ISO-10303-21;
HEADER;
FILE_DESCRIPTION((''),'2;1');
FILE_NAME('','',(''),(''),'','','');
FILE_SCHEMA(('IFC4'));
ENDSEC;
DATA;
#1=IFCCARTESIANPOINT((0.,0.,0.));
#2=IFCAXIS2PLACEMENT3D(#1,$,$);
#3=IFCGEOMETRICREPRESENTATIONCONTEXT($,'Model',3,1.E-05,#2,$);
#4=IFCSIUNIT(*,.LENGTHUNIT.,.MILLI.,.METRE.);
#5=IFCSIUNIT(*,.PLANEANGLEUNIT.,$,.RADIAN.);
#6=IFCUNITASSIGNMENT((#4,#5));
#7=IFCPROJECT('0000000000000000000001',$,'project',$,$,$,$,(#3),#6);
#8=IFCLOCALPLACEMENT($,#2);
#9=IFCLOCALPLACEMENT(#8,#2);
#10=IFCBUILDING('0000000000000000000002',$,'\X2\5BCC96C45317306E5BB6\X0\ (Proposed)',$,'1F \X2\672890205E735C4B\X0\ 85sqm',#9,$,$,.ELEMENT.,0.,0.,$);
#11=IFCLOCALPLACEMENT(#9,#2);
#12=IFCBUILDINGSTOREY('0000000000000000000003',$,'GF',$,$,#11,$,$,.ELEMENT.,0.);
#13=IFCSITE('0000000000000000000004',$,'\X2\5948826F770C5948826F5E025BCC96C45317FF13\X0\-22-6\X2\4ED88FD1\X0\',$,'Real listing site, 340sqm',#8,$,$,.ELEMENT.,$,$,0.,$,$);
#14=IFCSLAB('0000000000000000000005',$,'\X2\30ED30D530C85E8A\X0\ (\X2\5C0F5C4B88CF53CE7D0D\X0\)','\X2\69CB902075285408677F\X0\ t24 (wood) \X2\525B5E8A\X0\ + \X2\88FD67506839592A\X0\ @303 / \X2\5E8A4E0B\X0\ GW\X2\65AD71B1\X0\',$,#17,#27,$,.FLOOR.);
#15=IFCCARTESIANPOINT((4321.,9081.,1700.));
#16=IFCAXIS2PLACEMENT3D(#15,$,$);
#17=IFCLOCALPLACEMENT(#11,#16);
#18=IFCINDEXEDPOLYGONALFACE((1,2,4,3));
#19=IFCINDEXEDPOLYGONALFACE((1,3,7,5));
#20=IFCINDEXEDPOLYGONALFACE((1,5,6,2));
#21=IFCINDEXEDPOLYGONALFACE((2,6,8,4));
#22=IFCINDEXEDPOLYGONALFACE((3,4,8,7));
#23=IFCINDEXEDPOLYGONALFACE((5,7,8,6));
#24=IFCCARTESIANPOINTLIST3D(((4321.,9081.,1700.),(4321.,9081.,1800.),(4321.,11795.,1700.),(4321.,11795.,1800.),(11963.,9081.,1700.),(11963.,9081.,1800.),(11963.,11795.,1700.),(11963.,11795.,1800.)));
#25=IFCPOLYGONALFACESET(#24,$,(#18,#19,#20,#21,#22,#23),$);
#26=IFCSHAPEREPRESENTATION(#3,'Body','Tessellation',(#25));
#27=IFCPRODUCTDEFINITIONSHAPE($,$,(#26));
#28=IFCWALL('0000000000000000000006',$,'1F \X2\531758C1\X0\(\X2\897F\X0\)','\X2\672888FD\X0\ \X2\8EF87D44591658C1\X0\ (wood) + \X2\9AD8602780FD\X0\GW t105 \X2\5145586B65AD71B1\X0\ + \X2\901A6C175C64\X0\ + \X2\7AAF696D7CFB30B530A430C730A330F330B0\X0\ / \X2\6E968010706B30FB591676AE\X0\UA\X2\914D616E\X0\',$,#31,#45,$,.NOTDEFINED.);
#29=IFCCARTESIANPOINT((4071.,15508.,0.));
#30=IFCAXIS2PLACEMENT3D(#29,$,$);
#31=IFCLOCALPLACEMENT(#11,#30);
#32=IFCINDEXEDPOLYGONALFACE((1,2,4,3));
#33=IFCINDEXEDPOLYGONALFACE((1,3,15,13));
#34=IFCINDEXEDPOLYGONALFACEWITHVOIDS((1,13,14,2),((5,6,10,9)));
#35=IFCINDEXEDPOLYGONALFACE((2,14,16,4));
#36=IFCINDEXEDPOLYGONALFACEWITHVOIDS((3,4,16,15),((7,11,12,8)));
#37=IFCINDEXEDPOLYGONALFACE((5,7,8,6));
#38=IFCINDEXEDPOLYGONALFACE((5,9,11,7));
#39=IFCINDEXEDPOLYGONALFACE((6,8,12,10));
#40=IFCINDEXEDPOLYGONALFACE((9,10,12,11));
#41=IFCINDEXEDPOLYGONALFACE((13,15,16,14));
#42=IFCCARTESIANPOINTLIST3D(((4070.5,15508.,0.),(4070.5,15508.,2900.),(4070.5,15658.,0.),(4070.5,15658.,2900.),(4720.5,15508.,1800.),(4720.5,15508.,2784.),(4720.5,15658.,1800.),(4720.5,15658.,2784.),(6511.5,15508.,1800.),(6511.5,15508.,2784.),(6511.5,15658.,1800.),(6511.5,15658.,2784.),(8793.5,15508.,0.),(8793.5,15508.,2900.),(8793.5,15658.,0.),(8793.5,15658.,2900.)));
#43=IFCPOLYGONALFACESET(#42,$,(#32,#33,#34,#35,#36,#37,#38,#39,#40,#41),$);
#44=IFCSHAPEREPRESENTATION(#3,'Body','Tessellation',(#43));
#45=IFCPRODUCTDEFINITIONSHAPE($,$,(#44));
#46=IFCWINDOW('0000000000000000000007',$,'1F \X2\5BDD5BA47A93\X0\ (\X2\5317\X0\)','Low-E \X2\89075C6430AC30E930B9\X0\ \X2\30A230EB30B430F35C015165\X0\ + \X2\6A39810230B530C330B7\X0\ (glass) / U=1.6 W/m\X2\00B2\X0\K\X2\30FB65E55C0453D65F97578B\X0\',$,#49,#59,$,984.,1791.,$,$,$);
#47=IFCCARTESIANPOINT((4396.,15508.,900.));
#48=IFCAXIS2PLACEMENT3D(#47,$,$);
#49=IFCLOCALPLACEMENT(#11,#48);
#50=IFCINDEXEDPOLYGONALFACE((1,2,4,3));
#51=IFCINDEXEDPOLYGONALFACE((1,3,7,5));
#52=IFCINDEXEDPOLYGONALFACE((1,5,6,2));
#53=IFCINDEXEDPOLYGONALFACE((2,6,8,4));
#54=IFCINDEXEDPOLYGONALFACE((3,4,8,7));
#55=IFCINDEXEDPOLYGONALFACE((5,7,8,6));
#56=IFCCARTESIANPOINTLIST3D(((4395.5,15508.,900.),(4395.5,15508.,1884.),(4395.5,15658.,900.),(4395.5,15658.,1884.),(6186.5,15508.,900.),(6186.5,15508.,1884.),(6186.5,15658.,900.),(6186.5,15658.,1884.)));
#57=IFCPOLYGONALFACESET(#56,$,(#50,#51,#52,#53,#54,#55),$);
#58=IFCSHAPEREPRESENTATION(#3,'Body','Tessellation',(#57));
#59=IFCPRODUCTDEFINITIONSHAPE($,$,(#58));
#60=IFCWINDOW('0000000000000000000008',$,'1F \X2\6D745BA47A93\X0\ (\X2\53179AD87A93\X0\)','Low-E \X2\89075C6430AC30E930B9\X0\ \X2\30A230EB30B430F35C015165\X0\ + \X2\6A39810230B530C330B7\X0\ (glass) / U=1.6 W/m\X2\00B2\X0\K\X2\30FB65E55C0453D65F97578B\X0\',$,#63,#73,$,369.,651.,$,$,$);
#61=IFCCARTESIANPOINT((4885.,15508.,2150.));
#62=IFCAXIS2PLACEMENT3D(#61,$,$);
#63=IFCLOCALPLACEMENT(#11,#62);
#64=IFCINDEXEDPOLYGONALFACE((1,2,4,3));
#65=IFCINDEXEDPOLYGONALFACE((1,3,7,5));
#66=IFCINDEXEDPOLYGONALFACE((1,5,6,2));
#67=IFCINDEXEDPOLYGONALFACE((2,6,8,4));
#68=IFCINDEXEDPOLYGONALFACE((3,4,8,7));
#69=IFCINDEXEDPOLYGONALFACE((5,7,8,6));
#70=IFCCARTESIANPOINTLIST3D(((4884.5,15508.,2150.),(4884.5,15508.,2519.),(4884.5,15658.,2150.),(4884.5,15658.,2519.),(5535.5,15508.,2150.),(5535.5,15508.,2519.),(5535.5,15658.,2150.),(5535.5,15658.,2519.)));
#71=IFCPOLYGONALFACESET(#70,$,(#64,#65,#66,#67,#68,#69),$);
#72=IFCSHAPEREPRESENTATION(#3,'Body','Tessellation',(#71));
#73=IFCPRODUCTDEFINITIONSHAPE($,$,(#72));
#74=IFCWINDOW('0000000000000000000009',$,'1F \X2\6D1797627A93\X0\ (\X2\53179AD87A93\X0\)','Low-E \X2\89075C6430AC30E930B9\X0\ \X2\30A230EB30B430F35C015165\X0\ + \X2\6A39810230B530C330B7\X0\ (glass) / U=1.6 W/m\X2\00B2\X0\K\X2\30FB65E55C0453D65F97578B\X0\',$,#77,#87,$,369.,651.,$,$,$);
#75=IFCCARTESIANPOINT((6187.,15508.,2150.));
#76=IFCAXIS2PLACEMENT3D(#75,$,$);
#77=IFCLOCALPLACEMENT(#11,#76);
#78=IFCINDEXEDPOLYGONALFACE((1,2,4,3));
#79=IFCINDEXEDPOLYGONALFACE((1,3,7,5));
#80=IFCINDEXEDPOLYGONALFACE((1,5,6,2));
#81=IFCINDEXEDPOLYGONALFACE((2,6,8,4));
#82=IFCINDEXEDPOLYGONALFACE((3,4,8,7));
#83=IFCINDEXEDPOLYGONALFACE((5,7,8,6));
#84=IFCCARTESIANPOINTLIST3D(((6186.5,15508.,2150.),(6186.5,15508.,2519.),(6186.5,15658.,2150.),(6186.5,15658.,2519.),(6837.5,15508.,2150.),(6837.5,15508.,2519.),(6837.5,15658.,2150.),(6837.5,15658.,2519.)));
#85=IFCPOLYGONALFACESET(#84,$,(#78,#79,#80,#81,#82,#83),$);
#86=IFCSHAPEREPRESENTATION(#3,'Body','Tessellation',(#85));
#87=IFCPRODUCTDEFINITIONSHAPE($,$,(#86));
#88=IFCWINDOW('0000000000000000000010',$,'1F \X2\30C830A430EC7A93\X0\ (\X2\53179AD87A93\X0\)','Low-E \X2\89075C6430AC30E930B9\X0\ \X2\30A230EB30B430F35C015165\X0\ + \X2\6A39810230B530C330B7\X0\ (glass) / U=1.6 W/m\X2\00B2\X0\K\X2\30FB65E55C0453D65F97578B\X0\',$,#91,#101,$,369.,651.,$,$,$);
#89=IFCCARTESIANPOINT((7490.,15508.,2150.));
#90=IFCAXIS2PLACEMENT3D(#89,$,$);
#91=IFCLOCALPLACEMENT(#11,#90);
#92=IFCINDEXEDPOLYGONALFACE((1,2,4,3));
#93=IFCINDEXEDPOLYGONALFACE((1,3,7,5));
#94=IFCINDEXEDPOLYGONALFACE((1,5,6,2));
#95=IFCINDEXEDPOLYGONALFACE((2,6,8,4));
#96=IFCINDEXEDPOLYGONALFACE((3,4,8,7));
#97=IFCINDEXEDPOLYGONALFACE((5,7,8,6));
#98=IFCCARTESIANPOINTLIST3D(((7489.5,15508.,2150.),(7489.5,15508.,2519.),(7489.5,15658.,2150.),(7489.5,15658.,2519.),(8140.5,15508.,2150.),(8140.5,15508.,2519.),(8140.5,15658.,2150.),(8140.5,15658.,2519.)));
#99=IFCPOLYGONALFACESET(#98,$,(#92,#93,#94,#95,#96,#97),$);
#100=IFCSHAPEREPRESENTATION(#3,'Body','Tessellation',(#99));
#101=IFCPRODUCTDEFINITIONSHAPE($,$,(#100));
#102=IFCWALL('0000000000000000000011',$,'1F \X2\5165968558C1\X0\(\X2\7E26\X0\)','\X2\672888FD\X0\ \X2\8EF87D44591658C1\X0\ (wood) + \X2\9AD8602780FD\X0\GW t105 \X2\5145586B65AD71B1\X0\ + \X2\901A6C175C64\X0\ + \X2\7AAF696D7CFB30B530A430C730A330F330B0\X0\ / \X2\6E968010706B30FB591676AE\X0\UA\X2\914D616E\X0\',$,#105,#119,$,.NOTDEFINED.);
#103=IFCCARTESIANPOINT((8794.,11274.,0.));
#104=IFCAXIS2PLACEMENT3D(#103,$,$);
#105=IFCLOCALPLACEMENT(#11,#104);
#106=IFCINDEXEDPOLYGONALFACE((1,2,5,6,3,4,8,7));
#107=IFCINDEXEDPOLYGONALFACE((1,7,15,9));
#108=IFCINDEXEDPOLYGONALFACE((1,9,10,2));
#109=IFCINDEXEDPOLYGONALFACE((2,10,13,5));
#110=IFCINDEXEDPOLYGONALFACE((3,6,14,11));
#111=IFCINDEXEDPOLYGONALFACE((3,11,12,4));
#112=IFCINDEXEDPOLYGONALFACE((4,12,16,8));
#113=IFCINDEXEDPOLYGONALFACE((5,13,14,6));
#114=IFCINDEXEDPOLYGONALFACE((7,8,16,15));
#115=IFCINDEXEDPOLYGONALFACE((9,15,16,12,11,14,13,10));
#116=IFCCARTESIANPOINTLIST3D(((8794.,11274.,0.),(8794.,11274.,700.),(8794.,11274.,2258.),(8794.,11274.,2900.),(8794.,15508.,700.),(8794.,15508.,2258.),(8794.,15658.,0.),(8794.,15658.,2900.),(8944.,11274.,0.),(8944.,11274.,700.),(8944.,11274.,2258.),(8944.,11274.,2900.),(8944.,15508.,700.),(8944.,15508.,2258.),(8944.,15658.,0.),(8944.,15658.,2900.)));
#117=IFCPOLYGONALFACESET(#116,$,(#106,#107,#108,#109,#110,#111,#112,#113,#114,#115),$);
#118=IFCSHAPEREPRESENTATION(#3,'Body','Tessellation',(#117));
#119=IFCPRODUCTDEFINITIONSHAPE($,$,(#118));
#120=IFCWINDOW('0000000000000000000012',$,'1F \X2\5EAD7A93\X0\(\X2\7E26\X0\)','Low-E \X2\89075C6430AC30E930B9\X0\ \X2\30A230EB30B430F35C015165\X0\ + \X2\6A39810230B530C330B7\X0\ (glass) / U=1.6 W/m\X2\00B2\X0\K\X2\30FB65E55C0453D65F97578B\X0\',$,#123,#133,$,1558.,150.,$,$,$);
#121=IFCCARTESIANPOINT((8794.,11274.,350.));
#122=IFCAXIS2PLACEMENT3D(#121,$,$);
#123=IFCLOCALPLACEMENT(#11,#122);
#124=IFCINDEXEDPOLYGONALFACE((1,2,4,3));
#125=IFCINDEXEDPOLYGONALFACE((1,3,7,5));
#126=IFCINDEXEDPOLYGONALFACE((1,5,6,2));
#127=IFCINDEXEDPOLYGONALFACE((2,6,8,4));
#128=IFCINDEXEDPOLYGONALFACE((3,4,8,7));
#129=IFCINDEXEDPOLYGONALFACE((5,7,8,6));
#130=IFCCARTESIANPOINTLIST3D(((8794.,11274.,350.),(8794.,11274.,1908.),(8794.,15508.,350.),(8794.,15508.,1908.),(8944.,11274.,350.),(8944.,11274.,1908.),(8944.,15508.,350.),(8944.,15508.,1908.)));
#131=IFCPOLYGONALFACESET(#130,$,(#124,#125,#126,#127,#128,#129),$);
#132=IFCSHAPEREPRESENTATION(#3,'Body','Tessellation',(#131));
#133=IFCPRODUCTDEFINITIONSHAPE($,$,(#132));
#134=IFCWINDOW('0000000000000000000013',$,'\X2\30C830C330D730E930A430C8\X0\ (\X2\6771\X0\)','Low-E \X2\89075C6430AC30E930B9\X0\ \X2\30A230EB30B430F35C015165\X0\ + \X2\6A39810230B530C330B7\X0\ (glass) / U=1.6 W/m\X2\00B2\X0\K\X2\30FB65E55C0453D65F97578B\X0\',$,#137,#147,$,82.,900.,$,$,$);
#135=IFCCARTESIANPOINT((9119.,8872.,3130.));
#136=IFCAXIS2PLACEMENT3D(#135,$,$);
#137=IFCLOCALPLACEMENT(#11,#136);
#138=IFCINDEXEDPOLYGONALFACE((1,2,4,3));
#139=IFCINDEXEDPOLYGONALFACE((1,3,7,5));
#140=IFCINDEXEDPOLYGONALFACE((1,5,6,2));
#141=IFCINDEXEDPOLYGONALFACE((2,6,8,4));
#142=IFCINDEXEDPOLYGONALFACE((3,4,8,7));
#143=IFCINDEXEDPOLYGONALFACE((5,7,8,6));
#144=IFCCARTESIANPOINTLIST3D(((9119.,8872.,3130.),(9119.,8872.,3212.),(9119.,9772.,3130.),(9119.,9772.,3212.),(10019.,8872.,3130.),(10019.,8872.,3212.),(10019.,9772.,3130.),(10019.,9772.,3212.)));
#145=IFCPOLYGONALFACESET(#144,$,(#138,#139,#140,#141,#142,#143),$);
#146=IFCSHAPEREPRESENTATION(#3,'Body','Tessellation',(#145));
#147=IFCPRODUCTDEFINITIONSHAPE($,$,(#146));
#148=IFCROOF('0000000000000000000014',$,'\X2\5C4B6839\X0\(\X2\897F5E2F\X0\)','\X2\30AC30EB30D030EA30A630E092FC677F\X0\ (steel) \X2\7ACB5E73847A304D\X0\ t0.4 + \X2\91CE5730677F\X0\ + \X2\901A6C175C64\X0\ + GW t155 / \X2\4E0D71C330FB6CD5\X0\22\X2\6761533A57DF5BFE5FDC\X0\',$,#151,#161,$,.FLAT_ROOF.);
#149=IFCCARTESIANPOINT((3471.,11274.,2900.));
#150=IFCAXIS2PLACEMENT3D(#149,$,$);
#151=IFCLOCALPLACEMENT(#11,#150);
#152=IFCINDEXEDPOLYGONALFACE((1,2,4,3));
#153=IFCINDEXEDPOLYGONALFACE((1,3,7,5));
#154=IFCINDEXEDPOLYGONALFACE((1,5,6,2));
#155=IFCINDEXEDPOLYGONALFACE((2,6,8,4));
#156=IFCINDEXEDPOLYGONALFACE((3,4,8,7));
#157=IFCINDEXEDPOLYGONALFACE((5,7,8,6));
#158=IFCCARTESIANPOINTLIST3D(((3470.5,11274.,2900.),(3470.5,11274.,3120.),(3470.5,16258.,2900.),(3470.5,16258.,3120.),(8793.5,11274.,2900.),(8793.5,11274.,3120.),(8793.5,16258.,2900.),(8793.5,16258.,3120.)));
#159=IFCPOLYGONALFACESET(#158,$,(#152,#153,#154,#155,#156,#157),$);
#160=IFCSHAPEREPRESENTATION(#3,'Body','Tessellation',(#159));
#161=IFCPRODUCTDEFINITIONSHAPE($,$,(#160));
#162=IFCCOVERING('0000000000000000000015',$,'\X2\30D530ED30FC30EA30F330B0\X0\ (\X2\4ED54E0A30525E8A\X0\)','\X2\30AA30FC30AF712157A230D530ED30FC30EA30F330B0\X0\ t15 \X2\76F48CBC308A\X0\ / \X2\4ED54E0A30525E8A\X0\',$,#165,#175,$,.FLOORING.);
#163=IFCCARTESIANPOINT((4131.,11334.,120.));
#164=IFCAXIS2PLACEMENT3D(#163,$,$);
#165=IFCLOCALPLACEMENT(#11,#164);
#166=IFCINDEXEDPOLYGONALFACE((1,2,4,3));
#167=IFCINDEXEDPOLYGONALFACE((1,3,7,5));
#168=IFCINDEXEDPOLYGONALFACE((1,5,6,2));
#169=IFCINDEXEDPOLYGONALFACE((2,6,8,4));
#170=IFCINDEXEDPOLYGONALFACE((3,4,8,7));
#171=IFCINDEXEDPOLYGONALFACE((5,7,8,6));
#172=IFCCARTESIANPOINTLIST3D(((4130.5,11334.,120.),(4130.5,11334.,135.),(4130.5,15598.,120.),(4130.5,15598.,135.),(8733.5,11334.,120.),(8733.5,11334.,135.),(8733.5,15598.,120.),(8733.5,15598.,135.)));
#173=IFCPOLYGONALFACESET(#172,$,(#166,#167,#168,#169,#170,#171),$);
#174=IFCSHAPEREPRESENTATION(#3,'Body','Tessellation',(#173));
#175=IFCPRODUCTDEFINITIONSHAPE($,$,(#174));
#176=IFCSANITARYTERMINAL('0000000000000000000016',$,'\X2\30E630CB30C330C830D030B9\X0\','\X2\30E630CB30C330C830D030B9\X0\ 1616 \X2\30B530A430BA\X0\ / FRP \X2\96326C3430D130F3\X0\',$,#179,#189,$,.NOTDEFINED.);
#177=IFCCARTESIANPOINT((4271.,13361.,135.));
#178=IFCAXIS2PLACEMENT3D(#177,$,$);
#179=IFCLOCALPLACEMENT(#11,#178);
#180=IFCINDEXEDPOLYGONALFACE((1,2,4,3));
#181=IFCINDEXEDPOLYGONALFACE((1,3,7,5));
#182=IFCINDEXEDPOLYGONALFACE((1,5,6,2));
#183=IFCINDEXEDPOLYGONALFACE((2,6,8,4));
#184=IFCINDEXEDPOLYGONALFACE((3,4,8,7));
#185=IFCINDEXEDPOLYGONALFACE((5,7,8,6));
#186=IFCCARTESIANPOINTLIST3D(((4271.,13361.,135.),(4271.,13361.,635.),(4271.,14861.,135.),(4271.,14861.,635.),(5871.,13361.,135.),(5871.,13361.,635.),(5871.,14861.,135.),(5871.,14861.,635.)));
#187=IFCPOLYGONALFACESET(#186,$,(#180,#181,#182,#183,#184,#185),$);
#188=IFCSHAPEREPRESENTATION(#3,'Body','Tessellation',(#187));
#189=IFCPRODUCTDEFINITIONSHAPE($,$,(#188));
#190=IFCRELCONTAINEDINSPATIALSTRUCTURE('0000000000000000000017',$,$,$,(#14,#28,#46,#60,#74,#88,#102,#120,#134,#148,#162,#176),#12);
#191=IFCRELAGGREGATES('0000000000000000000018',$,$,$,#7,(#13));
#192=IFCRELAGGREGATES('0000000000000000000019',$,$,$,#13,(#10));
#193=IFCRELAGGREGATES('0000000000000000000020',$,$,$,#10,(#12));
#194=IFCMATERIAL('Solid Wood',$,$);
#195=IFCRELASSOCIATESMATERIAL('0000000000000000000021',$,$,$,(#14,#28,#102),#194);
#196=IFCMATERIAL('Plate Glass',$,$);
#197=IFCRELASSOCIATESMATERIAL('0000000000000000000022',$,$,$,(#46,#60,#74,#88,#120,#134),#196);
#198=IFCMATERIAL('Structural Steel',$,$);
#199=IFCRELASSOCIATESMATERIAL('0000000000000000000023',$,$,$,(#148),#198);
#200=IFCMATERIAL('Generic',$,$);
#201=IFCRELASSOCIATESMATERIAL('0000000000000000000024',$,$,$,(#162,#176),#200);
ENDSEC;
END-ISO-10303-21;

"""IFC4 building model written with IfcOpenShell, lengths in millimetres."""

from ifc_helpers import new_model, si_unit, frame, frame_2d, origin, place, context, project, spatial, rectangle, extrude, material, element, fill, save


model = new_model("IFC4")

# Units and contexts
model_context = context("Model", 3, precision=1e-05, world=origin())
ifc_project = project(units=[si_unit("LENGTHUNIT", "METRE", prefix="MILLI"), si_unit("PLANEANGLEUNIT", "RADIAN")], contexts=[model_context])

# Site, building, storey
site_placement = place(None, origin())
site = spatial("IfcSite", under=ifc_project, at=site_placement, Name="奈良県奈良市富雄北３-22-6付近", ObjectType="Real listing site, 340sqm", CompositionType="ELEMENT", RefElevation=0.0)
building_placement = place(site_placement, origin())
building = spatial("IfcBuilding", under=site, at=building_placement, Name="富雄北の家 (Proposed)", ObjectType="1F 木造平屋 85sqm", CompositionType="ELEMENT", ElevationOfRefHeight=0.0, ElevationOfTerrain=0.0)
storey_placement = place(building_placement, origin())
storey = spatial("IfcBuildingStorey", under=building, at=storey_placement, Name="GF", CompositionType="ELEMENT", Elevation=0.0)

# Slab
ifc_material_1 = material(Name="Solid Wood")
slab_1_placement = place(storey_placement, frame((4321.0, 9081.0, 1700.0)))
element("IfcSlab", 1, at=slab_1_placement, inside=storey, material=ifc_material_1, Name="ロフト床 (小屋裏収納)", Description="構造用合板 t24 (wood) 剛床 + 製材根太 @303 / 床下 GW断熱", PredefinedType="FLOOR", context=model_context, shape_type="SweptSolid", body=[
    extrude(rectangle(XDim=7642.0, YDim=2714.0, at=frame_2d((3821.0, 1357.0))), frame((4321.0, 9081.0, 1700.0)), (0.0, 0.0, 1.0), 100.0),
])

# Wall, openings, windows
wall_1_placement = place(storey_placement, frame((4071.0, 15508.0, 0.0)))
wall_1 = element("IfcWall", 2, at=wall_1_placement, inside=storey, material=ifc_material_1, Name="1F 北壁(西)", Description="木製 軸組外壁 (wood) + 高性能GW t105 充填断熱 + 通気層 + 窯業系サイディング / 準耐火・外皮UA配慮", PredefinedType="NOTDEFINED", context=model_context, shape_type="SweptSolid", body=[
    extrude(rectangle(XDim=4723.0, YDim=150.0, at=frame_2d((2361.0, 75.0))), frame((4071.0, 15508.0, 0.0)), (0.0, 0.0, 1.0), 2900.0),
])
opening_1_placement = place(storey_placement, frame((4396.0, 15508.0, 900.0)))
opening_1 = element("IfcOpeningElement", 3, at=opening_1_placement, cuts=wall_1, PredefinedType="NOTDEFINED", context=model_context, shape_type="SweptSolid", body=[
    extrude(rectangle(XDim=1791.0, YDim=150.0, at=frame_2d((895.0, 75.0))), frame((4396.0, 15508.0, 900.0)), (0.0, 0.0, 1.0), 984.0),
])
opening_2_placement = place(storey_placement, frame((4885.0, 15508.0, 2150.0)))
opening_2 = element("IfcOpeningElement", 4, at=opening_2_placement, cuts=wall_1, PredefinedType="NOTDEFINED", context=model_context, shape_type="SweptSolid", body=[
    extrude(rectangle(XDim=651.0, YDim=150.0, at=frame_2d((325.0, 75.0))), frame((4885.0, 15508.0, 2150.0)), (0.0, 0.0, 1.0), 369.0),
])
opening_3_placement = place(storey_placement, frame((6187.0, 15508.0, 2150.0)))
opening_3 = element("IfcOpeningElement", 5, at=opening_3_placement, cuts=wall_1, PredefinedType="NOTDEFINED", context=model_context, shape_type="SweptSolid", body=[
    extrude(rectangle(XDim=651.0, YDim=150.0, at=frame_2d((325.0, 75.0))), frame((6187.0, 15508.0, 2150.0)), (0.0, 0.0, 1.0), 369.0),
])
opening_4_placement = place(storey_placement, frame((7490.0, 15508.0, 2150.0)))
opening_4 = element("IfcOpeningElement", 6, at=opening_4_placement, cuts=wall_1, PredefinedType="NOTDEFINED", context=model_context, shape_type="SweptSolid", body=[
    extrude(rectangle(XDim=651.0, YDim=150.0, at=frame_2d((325.0, 75.0))), frame((7490.0, 15508.0, 2150.0)), (0.0, 0.0, 1.0), 369.0),
])
ifc_material_2 = material(Name="Plate Glass")
window_1_placement = place(storey_placement, frame((4396.0, 15508.0, 900.0)))
window_1 = element("IfcWindow", 7, at=window_1_placement, inside=storey, material=ifc_material_2, Name="1F 寝室窓 (北)", Description="Low-E 複層ガラス アルゴン封入 + 樹脂サッシ (glass) / U=1.6 W/m²K・日射取得型", OverallHeight=984.0, OverallWidth=1791.0, context=model_context, shape_type="SweptSolid", body=[
    extrude(rectangle(XDim=1791.0, YDim=150.0, at=frame_2d((895.0, 75.0))), frame((4396.0, 15508.0, 900.0)), (0.0, 0.0, 1.0), 984.0),
])
fill(opening_1, window_1)
window_2_placement = place(storey_placement, frame((4885.0, 15508.0, 2150.0)))
window_2 = element("IfcWindow", 8, at=window_2_placement, inside=storey, material=ifc_material_2, Name="1F 浴室窓 (北高窓)", Description="Low-E 複層ガラス アルゴン封入 + 樹脂サッシ (glass) / U=1.6 W/m²K・日射取得型", OverallHeight=369.0, OverallWidth=651.0, context=model_context, shape_type="SweptSolid", body=[
    extrude(rectangle(XDim=651.0, YDim=150.0, at=frame_2d((325.0, 75.0))), frame((4885.0, 15508.0, 2150.0)), (0.0, 0.0, 1.0), 369.0),
])
fill(opening_2, window_2)
window_3_placement = place(storey_placement, frame((6187.0, 15508.0, 2150.0)))
window_3 = element("IfcWindow", 9, at=window_3_placement, inside=storey, material=ifc_material_2, Name="1F 洗面窓 (北高窓)", Description="Low-E 複層ガラス アルゴン封入 + 樹脂サッシ (glass) / U=1.6 W/m²K・日射取得型", OverallHeight=369.0, OverallWidth=651.0, context=model_context, shape_type="SweptSolid", body=[
    extrude(rectangle(XDim=651.0, YDim=150.0, at=frame_2d((325.0, 75.0))), frame((6187.0, 15508.0, 2150.0)), (0.0, 0.0, 1.0), 369.0),
])
fill(opening_3, window_3)
window_4_placement = place(storey_placement, frame((7490.0, 15508.0, 2150.0)))
window_4 = element("IfcWindow", 10, at=window_4_placement, inside=storey, material=ifc_material_2, Name="1F トイレ窓 (北高窓)", Description="Low-E 複層ガラス アルゴン封入 + 樹脂サッシ (glass) / U=1.6 W/m²K・日射取得型", OverallHeight=369.0, OverallWidth=651.0, context=model_context, shape_type="SweptSolid", body=[
    extrude(rectangle(XDim=651.0, YDim=150.0, at=frame_2d((325.0, 75.0))), frame((7490.0, 15508.0, 2150.0)), (0.0, 0.0, 1.0), 369.0),
])
fill(opening_4, window_4)

# Wall, opening, window
wall_2_placement = place(storey_placement, frame((8794.0, 11274.0, 0.0)))
wall_2 = element("IfcWall", 11, at=wall_2_placement, inside=storey, material=ifc_material_1, Name="1F 入隅壁(縦)", Description="木製 軸組外壁 (wood) + 高性能GW t105 充填断熱 + 通気層 + 窯業系サイディング / 準耐火・外皮UA配慮", PredefinedType="NOTDEFINED", context=model_context, shape_type="SweptSolid", body=[
    extrude(rectangle(XDim=150.0, YDim=4384.0, at=frame_2d((75.0, 2192.0))), frame((8794.0, 11274.0, 0.0)), (0.0, 0.0, 1.0), 2900.0),
])
opening_5_placement = place(storey_placement, frame((8794.0, 11274.0, 350.0)))
opening_5 = element("IfcOpeningElement", 12, at=opening_5_placement, cuts=wall_2, PredefinedType="NOTDEFINED", context=model_context, shape_type="SweptSolid", body=[
    extrude(rectangle(XDim=150.0, YDim=4234.0, at=frame_2d((75.0, 2117.0))), frame((8794.0, 11274.0, 350.0)), (0.0, 0.0, 1.0), 1558.0),
])
window_5_placement = place(storey_placement, frame((8794.0, 11274.0, 350.0)))
window_5 = element("IfcWindow", 13, at=window_5_placement, inside=storey, material=ifc_material_2, Name="1F 庭窓(縦)", Description="Low-E 複層ガラス アルゴン封入 + 樹脂サッシ (glass) / U=1.6 W/m²K・日射取得型", OverallHeight=1558.0, OverallWidth=150.0, context=model_context, shape_type="SweptSolid", body=[
    extrude(rectangle(XDim=150.0, YDim=4234.0, at=frame_2d((75.0, 2117.0))), frame((8794.0, 11274.0, 350.0)), (0.0, 0.0, 1.0), 1558.0),
])
fill(opening_5, window_5)

# Window
window_6_placement = place(storey_placement, frame((9119.0, 8872.0, 3130.0)))
element("IfcWindow", 14, at=window_6_placement, inside=storey, material=ifc_material_2, Name="トップライト (東)", Description="Low-E 複層ガラス アルゴン封入 + 樹脂サッシ (glass) / U=1.6 W/m²K・日射取得型", OverallHeight=82.0, OverallWidth=900.0, context=model_context, shape_type="SweptSolid", body=[
    extrude(rectangle(XDim=900.0, YDim=900.0, at=frame_2d((450.0, 450.0))), frame((9119.0, 8872.0, 3130.0)), (0.0, 0.0, 1.0), 82.0),
])

# Roof
ifc_material_3 = material(Name="Structural Steel")
roof_placement = place(storey_placement, frame((3471.0, 11274.0, 2900.0)))
element("IfcRoof", 15, at=roof_placement, inside=storey, material=ifc_material_3, Name="屋根(西帯)", Description="ガルバリウム鋼板 (steel) 立平葺き t0.4 + 野地板 + 通気層 + GW t155 / 不燃・法22条区域対応", PredefinedType="FLAT_ROOF", context=model_context, shape_type="SweptSolid", body=[
    extrude(rectangle(XDim=5323.0, YDim=4984.0, at=frame_2d((2661.0, 2492.0))), frame((3471.0, 11274.0, 2900.0)), (0.0, 0.0, 1.0), 220.0),
])

# Covering
ifc_material_4 = material(Name="Generic")
covering_placement = place(storey_placement, frame((4131.0, 11334.0, 120.0)))
element("IfcCovering", 16, at=covering_placement, inside=storey, material=ifc_material_4, Name="フローリング (仕上げ床)", Description="オーク無垢フローリング t15 直貼り / 仕上げ床", PredefinedType="FLOORING", context=model_context, shape_type="SweptSolid", body=[
    extrude(rectangle(XDim=4603.0, YDim=4264.0, at=frame_2d((2301.0, 2132.0))), frame((4131.0, 11334.0, 120.0)), (0.0, 0.0, 1.0), 15.0),
])

# Sanitary terminal
sanitary_terminal_1_placement = place(storey_placement, frame((4271.0, 13361.0, 135.0)))
element("IfcSanitaryTerminal", 17, at=sanitary_terminal_1_placement, inside=storey, material=ifc_material_4, Name="ユニットバス", Description="ユニットバス 1616 サイズ / FRP 防水パン", PredefinedType="NOTDEFINED", context=model_context, shape_type="SweptSolid", body=[
    extrude(rectangle(XDim=1600.0, YDim=1500.0, at=frame_2d((800.0, 750.0))), frame((4271.0, 13361.0, 135.0)), (0.0, 0.0, 1.0), 500.0),
])

save(model, "model.ifc")
